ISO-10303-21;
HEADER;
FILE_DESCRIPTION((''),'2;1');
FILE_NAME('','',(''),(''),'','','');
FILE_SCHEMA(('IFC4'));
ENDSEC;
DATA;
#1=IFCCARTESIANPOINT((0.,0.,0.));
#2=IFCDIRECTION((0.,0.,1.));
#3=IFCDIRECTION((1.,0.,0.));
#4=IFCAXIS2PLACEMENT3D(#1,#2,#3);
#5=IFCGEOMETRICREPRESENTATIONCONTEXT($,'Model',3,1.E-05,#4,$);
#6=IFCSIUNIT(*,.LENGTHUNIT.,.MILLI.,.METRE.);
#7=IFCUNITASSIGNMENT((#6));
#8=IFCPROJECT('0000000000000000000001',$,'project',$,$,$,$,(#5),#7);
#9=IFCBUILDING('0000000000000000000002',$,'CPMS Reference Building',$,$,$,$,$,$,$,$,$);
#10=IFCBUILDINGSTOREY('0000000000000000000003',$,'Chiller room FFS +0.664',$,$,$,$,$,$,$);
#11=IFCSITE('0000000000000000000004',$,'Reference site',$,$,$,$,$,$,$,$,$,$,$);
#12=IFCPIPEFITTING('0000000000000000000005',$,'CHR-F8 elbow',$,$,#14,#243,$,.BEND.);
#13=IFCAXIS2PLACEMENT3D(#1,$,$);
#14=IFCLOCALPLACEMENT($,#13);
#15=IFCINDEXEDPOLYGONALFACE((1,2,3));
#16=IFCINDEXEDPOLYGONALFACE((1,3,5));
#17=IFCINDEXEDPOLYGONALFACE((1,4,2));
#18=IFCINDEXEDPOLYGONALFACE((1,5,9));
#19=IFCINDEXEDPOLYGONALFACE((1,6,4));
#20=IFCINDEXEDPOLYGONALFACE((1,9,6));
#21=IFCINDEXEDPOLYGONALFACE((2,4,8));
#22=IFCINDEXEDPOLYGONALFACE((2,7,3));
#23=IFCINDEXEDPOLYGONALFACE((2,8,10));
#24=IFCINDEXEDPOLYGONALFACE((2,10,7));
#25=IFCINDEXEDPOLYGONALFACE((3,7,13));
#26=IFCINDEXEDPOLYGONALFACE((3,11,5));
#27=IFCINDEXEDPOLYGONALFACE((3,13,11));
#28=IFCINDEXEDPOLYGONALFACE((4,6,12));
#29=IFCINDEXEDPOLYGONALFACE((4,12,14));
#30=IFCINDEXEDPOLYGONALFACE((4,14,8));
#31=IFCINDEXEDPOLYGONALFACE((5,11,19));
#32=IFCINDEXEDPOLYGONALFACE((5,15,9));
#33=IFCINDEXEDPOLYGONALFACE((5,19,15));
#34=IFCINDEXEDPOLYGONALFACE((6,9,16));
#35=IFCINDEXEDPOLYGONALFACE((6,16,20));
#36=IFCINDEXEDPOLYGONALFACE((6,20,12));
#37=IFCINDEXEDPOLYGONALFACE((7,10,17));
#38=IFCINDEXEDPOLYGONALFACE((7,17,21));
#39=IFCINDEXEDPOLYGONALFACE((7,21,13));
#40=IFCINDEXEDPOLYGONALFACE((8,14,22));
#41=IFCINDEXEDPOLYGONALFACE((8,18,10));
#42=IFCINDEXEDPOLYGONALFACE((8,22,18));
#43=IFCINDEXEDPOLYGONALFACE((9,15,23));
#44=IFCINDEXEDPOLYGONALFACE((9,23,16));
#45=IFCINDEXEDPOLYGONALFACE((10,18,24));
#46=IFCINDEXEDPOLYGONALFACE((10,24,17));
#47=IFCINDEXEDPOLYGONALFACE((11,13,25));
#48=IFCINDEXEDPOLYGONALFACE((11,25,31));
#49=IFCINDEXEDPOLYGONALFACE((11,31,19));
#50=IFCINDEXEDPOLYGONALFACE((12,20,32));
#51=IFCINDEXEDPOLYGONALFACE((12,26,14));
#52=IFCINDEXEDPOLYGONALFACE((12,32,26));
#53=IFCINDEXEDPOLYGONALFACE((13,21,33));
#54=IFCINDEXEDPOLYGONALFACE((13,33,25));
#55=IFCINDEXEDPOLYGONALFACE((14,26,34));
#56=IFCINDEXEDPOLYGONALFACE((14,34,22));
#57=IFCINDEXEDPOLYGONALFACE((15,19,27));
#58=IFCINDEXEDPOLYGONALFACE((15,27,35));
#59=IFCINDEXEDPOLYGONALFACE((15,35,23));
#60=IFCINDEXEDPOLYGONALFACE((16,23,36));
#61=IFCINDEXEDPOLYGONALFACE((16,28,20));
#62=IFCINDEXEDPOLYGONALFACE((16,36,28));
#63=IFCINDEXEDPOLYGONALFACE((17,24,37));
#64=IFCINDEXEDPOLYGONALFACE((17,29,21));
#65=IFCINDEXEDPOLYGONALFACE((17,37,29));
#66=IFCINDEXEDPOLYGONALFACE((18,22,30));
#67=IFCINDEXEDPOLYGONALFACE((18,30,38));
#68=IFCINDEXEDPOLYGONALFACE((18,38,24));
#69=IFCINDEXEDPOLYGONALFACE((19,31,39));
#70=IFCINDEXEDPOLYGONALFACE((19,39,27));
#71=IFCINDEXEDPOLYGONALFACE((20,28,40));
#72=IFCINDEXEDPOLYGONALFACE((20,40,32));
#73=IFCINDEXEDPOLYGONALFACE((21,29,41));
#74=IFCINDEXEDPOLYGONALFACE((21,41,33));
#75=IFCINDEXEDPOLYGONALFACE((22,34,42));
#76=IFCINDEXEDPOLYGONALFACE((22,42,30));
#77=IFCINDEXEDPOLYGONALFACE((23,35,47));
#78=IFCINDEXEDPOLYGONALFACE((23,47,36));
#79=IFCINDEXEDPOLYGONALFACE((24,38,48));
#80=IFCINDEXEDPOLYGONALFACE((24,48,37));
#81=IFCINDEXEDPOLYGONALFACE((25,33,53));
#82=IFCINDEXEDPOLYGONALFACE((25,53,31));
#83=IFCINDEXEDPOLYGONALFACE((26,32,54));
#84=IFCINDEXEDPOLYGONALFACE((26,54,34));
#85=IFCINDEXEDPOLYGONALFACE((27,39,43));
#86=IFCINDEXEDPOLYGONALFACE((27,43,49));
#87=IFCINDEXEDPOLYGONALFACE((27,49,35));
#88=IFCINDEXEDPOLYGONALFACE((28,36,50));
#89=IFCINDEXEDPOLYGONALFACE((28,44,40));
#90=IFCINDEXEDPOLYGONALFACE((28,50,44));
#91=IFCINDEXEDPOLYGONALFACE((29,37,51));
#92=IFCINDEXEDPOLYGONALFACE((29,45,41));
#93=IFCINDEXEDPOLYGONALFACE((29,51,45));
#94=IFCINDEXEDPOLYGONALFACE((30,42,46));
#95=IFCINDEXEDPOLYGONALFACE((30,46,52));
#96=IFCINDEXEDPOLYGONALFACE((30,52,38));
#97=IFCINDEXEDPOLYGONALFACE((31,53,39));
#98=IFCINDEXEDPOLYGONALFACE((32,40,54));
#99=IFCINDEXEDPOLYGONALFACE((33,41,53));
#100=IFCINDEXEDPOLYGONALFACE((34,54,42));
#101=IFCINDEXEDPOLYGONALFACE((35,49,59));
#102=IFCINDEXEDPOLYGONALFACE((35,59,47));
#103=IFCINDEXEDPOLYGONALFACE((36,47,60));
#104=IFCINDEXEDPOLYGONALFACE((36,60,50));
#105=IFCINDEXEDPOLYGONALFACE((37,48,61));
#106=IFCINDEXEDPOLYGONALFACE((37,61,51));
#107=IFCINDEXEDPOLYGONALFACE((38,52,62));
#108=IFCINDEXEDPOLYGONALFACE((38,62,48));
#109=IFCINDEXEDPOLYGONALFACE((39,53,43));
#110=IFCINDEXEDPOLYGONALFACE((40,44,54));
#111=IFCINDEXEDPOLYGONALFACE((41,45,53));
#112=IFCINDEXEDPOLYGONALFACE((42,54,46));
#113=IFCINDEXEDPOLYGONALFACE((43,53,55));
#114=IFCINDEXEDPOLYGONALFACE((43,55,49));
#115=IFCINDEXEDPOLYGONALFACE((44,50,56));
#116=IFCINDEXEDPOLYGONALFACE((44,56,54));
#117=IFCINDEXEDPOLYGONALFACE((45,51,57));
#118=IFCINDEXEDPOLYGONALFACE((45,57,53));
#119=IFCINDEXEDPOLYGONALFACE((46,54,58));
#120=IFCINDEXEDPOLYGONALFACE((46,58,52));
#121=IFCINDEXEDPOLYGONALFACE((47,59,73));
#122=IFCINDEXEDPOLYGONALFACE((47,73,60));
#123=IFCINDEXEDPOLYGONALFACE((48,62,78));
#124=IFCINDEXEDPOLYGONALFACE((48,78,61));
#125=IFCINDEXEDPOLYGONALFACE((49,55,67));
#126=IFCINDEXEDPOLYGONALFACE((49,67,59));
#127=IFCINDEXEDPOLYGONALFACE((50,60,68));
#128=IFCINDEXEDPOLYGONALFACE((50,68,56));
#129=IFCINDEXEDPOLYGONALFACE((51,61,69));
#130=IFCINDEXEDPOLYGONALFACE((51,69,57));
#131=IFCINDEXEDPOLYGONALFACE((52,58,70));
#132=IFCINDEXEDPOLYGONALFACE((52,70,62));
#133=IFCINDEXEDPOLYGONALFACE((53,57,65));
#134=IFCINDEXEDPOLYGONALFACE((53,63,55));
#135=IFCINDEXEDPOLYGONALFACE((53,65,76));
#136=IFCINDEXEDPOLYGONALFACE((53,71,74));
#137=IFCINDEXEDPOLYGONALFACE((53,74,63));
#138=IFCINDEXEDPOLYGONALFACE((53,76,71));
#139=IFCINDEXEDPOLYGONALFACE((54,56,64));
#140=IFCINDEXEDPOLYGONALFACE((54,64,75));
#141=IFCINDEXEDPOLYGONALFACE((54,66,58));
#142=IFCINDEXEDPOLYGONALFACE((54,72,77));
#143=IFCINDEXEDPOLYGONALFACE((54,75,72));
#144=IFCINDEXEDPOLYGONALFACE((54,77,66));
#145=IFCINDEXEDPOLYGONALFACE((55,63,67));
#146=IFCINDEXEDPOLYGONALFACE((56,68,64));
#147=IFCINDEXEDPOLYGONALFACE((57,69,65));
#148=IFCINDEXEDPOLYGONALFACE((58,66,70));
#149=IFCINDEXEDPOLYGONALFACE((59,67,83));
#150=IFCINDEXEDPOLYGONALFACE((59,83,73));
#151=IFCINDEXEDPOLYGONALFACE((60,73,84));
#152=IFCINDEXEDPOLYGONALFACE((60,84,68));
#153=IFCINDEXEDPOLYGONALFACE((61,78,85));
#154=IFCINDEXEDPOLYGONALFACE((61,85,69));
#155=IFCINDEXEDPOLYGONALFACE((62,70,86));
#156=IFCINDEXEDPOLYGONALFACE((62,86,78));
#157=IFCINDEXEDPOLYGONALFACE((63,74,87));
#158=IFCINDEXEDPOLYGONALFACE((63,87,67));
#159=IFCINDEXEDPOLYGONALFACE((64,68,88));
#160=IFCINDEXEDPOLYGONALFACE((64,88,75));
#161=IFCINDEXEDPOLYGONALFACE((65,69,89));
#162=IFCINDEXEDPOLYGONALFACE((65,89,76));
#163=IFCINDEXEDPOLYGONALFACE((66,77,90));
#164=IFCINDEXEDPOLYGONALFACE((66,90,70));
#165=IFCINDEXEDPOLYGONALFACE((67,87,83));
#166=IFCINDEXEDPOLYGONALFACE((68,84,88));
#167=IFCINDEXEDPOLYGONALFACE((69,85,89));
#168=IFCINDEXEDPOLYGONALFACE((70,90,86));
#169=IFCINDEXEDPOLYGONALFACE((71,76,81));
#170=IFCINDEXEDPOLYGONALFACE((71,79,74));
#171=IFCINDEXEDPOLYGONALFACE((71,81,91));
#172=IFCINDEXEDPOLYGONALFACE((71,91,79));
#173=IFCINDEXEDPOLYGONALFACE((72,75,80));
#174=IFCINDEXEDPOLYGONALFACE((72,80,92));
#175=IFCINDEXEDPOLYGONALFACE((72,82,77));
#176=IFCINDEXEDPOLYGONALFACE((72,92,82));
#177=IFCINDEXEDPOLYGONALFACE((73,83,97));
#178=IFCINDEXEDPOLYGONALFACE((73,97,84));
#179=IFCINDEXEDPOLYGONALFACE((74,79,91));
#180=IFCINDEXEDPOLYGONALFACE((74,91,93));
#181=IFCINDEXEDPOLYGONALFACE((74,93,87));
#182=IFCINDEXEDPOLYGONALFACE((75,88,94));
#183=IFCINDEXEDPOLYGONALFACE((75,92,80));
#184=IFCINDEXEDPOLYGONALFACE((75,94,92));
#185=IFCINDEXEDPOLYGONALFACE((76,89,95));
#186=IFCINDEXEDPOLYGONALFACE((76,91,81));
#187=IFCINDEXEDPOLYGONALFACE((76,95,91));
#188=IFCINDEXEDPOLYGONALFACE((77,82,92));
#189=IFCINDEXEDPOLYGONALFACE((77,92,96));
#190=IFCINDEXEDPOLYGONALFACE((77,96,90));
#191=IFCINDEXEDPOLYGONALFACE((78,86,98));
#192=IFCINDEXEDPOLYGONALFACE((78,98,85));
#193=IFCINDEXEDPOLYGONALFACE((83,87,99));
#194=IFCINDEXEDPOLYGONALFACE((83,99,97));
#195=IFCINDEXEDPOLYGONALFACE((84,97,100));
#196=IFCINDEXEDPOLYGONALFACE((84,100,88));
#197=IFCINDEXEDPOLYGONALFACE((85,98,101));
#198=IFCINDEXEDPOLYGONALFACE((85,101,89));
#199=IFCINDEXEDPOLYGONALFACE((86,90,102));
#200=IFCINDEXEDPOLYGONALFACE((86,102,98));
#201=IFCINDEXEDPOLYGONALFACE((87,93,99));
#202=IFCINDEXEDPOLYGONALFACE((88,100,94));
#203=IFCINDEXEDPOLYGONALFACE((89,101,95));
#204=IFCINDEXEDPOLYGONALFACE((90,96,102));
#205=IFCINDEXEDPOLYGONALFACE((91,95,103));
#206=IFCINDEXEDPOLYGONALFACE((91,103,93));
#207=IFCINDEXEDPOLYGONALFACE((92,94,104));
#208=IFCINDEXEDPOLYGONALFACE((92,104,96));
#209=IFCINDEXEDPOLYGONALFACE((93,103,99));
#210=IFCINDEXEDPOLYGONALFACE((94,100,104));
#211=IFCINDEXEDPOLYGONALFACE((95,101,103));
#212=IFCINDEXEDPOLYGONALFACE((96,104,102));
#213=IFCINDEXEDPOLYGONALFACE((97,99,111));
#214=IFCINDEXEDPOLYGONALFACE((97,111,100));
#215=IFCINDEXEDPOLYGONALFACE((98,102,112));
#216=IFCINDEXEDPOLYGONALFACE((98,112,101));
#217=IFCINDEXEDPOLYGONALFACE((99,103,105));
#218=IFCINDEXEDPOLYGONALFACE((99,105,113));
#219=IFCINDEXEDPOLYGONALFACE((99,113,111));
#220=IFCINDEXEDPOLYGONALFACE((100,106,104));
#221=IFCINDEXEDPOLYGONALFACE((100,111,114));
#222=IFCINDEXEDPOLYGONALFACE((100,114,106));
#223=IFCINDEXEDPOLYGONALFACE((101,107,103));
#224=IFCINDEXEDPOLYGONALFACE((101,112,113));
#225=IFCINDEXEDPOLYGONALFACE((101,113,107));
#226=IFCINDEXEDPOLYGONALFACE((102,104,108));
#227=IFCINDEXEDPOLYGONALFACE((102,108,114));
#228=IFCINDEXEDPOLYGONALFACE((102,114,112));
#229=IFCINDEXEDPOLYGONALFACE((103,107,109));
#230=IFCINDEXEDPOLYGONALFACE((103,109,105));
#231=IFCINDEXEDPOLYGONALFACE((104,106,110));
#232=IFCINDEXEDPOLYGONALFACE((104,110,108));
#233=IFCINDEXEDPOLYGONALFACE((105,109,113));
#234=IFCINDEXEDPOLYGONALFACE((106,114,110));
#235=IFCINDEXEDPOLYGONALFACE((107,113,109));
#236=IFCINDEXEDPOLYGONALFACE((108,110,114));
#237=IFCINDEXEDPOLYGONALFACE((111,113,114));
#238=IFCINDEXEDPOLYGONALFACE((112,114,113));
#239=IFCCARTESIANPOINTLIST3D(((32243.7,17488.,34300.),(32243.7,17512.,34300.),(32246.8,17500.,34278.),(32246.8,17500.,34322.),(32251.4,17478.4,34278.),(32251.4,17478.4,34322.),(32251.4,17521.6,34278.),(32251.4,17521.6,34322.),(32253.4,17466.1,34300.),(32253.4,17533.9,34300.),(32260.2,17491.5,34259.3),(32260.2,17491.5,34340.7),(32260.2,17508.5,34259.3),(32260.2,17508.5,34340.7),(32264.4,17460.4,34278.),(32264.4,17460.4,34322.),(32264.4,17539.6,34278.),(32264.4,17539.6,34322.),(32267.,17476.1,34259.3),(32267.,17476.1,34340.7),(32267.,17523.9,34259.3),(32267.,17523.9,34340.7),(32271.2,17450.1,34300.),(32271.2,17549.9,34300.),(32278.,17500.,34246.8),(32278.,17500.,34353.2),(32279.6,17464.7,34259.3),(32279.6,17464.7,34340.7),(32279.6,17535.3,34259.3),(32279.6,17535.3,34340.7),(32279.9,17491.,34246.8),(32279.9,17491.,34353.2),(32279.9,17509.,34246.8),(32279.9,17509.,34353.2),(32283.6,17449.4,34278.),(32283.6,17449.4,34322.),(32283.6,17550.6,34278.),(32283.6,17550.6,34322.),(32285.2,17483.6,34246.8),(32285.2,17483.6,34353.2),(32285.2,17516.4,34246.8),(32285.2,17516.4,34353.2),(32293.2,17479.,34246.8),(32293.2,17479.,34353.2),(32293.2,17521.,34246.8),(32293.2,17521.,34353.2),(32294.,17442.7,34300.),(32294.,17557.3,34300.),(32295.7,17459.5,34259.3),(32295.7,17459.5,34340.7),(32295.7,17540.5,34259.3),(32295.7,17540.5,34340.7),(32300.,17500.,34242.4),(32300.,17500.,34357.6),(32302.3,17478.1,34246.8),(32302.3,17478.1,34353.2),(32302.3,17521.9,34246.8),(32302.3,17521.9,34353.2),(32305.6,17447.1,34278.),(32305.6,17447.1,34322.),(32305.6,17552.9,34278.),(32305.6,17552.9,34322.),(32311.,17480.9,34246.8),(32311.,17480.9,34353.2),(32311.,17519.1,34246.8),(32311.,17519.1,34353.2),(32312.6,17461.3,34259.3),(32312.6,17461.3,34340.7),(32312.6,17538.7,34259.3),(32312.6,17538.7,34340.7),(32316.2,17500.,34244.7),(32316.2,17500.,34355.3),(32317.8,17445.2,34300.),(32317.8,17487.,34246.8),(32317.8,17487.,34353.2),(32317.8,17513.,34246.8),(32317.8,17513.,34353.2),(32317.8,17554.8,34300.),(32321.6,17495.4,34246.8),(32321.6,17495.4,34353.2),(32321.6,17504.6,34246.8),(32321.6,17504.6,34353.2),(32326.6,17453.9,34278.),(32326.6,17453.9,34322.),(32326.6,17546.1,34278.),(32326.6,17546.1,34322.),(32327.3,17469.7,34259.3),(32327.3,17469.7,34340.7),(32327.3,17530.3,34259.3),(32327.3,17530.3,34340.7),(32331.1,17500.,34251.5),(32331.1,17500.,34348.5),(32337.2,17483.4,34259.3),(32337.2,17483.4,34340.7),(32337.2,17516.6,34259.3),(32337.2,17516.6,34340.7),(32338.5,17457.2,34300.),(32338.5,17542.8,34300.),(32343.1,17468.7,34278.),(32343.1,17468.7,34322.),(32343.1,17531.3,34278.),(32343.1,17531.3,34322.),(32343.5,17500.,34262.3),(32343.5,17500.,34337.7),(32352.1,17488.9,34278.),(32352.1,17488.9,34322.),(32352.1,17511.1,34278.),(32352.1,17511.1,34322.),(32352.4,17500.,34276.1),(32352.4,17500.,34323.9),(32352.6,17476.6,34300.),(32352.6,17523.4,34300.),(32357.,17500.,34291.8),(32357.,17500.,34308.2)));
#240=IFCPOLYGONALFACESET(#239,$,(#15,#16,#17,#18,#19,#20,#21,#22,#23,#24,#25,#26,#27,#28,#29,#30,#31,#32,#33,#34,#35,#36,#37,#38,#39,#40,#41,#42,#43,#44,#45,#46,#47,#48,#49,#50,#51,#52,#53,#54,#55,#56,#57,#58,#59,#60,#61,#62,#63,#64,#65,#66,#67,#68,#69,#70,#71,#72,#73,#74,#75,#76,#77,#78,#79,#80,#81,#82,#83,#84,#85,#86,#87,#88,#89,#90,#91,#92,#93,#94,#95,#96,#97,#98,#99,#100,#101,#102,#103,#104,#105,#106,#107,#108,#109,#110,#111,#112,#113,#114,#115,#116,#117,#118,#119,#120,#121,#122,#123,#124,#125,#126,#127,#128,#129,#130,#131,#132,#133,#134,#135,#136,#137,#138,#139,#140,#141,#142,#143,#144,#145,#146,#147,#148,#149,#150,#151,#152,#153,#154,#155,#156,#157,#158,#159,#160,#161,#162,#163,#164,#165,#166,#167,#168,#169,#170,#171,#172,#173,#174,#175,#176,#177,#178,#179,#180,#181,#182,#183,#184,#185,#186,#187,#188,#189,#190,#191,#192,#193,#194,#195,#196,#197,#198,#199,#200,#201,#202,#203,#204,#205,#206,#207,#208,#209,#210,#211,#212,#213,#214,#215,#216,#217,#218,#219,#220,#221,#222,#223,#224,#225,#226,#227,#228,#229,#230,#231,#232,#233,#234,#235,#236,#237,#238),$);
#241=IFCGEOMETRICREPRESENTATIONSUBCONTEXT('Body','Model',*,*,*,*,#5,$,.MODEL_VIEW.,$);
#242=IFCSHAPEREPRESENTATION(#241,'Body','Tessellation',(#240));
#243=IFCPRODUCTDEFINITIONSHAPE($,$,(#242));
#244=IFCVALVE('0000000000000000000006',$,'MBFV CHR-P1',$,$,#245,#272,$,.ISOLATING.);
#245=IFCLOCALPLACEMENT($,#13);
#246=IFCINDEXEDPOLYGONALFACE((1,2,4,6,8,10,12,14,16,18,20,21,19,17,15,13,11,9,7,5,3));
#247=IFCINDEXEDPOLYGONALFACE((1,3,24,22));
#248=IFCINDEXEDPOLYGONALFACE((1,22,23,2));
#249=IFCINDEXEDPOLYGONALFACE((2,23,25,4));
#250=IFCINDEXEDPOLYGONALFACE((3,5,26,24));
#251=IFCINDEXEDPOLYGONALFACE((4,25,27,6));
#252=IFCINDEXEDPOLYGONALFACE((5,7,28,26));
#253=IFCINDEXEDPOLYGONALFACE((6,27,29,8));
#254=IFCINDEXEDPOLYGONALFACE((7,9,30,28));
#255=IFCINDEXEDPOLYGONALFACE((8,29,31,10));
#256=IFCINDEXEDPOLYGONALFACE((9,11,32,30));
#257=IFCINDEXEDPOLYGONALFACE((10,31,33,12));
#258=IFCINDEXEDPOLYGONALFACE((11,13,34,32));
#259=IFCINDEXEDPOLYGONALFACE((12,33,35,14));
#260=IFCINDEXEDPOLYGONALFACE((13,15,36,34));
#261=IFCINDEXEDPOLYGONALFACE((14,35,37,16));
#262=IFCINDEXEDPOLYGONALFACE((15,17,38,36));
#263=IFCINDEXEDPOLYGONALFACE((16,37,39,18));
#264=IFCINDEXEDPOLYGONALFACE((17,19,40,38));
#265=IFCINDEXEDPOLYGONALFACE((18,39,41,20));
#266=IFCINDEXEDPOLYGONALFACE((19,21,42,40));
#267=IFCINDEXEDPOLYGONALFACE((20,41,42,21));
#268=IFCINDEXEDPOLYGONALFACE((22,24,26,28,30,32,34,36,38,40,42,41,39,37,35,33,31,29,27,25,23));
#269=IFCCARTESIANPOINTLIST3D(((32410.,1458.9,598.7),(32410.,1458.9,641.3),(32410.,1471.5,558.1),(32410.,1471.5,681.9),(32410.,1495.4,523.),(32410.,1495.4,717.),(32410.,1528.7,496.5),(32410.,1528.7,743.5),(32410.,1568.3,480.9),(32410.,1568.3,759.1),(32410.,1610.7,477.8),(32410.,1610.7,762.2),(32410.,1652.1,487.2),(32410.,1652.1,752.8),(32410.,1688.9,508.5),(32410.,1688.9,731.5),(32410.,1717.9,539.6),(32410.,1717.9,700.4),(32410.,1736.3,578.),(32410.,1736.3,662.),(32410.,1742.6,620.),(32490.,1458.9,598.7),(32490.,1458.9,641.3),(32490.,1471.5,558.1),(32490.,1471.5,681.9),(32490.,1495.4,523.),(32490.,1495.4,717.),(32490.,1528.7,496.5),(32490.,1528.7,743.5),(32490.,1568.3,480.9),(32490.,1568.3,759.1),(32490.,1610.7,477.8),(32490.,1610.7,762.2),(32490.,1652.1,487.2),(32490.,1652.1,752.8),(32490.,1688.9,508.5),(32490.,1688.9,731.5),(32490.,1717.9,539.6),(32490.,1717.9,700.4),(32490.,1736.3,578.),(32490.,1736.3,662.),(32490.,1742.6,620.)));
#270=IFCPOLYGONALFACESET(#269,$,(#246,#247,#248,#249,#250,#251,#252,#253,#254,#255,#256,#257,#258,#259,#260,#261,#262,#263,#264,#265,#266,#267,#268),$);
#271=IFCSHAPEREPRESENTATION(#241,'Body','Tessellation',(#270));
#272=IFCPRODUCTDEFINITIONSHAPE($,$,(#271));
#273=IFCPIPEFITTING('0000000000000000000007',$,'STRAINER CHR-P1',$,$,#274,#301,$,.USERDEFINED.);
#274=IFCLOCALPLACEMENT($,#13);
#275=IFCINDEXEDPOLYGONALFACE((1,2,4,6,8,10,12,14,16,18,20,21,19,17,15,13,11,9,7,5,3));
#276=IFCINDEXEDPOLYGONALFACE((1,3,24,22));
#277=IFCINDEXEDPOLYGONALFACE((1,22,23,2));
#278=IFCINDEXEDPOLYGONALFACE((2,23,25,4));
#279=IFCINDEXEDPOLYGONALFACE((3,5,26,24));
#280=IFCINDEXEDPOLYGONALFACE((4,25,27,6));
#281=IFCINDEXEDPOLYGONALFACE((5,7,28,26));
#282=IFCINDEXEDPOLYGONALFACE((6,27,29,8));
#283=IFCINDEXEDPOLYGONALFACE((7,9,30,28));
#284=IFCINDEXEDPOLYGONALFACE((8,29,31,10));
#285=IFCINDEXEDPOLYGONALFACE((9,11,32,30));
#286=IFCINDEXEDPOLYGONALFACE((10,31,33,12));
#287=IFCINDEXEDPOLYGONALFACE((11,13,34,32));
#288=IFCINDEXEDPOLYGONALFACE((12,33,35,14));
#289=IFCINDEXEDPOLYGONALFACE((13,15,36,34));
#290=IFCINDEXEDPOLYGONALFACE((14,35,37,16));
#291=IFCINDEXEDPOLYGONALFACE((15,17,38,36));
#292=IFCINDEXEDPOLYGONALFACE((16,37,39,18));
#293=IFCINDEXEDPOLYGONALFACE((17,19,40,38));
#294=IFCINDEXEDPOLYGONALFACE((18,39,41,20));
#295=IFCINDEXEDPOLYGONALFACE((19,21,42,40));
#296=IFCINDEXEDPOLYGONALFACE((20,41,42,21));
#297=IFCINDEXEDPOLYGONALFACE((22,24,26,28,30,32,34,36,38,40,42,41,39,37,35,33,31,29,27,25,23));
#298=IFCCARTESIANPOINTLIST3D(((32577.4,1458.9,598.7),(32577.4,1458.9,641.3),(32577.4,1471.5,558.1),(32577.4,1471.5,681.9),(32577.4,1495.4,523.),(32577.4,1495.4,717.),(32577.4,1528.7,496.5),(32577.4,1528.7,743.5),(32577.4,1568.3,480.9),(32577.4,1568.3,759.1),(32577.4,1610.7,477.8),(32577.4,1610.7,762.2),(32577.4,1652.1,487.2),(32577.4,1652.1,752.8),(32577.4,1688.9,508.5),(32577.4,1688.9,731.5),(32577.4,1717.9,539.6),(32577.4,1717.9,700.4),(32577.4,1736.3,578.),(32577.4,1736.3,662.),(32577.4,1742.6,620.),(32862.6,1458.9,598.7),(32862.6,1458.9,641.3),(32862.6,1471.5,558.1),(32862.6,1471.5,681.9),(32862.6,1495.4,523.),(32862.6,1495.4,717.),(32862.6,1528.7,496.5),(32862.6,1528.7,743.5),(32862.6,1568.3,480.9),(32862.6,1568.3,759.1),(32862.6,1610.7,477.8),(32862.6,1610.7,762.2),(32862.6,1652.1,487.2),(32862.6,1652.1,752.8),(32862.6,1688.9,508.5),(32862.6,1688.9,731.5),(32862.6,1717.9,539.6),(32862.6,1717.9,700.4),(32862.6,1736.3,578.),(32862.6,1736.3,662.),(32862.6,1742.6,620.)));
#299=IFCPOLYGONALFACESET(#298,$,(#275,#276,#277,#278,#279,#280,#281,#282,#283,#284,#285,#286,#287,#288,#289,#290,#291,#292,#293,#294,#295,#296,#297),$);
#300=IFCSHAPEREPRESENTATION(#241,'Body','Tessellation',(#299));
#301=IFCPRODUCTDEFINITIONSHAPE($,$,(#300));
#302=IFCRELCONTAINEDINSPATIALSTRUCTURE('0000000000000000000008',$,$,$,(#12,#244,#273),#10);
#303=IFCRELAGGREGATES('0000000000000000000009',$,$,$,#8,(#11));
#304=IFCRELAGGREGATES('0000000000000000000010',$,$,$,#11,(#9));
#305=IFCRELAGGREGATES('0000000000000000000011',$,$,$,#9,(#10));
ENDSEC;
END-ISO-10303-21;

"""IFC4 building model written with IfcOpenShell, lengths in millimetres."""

from ifc_helpers import new_model, entity, si_unit, frame, origin_with_axes, origin_2d, place, context, subcontext, project, spatial, circle_curve, outline, extrude, element, save


model = new_model("IFC4")

# Units and contexts
model_context = context("Model", 3, precision=1e-05, world=origin_with_axes())
body_context = subcontext(model_context, "Body", "Model", "MODEL_VIEW")
ifc_project = project(units=[si_unit("LENGTHUNIT", "METRE", prefix="MILLI")], contexts=[model_context])

# Site, building, storey
site = spatial("IfcSite", under=ifc_project, Name="Reference site")
building = spatial("IfcBuilding", under=site, Name="CPMS Reference Building")
storey = spatial("IfcBuildingStorey", under=building, Name="Chiller room FFS +0.664")

# Pipe fitting
pipe_fitting_1_placement = place(None, origin_with_axes())
element("IfcPipeFitting", 1, at=pipe_fitting_1_placement, inside=storey, Name="CHR-F8 elbow", PredefinedType="BEND", context=body_context, shape_type="CSG", body=[
    entity("IfcSphere", entity("IfcAxis2Placement3D", entity("IfcCartesianPoint", [32300.0, 17500.0, 34300.0]), entity("IfcDirection", [0.0, 0.0, 1.0]), entity("IfcDirection", [1.0, 0.0, 0.0])), 57.6),
])

# Valve
valve_1_placement = place(None, origin_with_axes())
element("IfcValve", 2, at=valve_1_placement, inside=storey, Name="MBFV CHR-P1", PredefinedType="ISOLATING", context=body_context, shape_type="SweptSolid", body=[
    extrude(outline(circle_curve(origin_2d(), 142.6)), frame((32410.0, 1600.0, 620.0), z_axis=(1.0, 0.0, 0.0), x_axis=(0.0, 1.0, 0.0)), (0.0, 0.0, 1.0), 80.0),
])

# Pipe fitting
pipe_fitting_2_placement = place(None, origin_with_axes())
element("IfcPipeFitting", 3, at=pipe_fitting_2_placement, inside=storey, Name="STRAINER CHR-P1", PredefinedType="USERDEFINED", context=body_context, shape_type="SweptSolid", body=[
    extrude(outline(circle_curve(origin_2d(), 142.6)), frame((32577.4, 1600.0, 620.0), z_axis=(1.0, 0.0, 0.0), x_axis=(0.0, 1.0, 0.0)), (0.0, 0.0, 1.0), 285.3),
])

save(model, "model.ifc")
